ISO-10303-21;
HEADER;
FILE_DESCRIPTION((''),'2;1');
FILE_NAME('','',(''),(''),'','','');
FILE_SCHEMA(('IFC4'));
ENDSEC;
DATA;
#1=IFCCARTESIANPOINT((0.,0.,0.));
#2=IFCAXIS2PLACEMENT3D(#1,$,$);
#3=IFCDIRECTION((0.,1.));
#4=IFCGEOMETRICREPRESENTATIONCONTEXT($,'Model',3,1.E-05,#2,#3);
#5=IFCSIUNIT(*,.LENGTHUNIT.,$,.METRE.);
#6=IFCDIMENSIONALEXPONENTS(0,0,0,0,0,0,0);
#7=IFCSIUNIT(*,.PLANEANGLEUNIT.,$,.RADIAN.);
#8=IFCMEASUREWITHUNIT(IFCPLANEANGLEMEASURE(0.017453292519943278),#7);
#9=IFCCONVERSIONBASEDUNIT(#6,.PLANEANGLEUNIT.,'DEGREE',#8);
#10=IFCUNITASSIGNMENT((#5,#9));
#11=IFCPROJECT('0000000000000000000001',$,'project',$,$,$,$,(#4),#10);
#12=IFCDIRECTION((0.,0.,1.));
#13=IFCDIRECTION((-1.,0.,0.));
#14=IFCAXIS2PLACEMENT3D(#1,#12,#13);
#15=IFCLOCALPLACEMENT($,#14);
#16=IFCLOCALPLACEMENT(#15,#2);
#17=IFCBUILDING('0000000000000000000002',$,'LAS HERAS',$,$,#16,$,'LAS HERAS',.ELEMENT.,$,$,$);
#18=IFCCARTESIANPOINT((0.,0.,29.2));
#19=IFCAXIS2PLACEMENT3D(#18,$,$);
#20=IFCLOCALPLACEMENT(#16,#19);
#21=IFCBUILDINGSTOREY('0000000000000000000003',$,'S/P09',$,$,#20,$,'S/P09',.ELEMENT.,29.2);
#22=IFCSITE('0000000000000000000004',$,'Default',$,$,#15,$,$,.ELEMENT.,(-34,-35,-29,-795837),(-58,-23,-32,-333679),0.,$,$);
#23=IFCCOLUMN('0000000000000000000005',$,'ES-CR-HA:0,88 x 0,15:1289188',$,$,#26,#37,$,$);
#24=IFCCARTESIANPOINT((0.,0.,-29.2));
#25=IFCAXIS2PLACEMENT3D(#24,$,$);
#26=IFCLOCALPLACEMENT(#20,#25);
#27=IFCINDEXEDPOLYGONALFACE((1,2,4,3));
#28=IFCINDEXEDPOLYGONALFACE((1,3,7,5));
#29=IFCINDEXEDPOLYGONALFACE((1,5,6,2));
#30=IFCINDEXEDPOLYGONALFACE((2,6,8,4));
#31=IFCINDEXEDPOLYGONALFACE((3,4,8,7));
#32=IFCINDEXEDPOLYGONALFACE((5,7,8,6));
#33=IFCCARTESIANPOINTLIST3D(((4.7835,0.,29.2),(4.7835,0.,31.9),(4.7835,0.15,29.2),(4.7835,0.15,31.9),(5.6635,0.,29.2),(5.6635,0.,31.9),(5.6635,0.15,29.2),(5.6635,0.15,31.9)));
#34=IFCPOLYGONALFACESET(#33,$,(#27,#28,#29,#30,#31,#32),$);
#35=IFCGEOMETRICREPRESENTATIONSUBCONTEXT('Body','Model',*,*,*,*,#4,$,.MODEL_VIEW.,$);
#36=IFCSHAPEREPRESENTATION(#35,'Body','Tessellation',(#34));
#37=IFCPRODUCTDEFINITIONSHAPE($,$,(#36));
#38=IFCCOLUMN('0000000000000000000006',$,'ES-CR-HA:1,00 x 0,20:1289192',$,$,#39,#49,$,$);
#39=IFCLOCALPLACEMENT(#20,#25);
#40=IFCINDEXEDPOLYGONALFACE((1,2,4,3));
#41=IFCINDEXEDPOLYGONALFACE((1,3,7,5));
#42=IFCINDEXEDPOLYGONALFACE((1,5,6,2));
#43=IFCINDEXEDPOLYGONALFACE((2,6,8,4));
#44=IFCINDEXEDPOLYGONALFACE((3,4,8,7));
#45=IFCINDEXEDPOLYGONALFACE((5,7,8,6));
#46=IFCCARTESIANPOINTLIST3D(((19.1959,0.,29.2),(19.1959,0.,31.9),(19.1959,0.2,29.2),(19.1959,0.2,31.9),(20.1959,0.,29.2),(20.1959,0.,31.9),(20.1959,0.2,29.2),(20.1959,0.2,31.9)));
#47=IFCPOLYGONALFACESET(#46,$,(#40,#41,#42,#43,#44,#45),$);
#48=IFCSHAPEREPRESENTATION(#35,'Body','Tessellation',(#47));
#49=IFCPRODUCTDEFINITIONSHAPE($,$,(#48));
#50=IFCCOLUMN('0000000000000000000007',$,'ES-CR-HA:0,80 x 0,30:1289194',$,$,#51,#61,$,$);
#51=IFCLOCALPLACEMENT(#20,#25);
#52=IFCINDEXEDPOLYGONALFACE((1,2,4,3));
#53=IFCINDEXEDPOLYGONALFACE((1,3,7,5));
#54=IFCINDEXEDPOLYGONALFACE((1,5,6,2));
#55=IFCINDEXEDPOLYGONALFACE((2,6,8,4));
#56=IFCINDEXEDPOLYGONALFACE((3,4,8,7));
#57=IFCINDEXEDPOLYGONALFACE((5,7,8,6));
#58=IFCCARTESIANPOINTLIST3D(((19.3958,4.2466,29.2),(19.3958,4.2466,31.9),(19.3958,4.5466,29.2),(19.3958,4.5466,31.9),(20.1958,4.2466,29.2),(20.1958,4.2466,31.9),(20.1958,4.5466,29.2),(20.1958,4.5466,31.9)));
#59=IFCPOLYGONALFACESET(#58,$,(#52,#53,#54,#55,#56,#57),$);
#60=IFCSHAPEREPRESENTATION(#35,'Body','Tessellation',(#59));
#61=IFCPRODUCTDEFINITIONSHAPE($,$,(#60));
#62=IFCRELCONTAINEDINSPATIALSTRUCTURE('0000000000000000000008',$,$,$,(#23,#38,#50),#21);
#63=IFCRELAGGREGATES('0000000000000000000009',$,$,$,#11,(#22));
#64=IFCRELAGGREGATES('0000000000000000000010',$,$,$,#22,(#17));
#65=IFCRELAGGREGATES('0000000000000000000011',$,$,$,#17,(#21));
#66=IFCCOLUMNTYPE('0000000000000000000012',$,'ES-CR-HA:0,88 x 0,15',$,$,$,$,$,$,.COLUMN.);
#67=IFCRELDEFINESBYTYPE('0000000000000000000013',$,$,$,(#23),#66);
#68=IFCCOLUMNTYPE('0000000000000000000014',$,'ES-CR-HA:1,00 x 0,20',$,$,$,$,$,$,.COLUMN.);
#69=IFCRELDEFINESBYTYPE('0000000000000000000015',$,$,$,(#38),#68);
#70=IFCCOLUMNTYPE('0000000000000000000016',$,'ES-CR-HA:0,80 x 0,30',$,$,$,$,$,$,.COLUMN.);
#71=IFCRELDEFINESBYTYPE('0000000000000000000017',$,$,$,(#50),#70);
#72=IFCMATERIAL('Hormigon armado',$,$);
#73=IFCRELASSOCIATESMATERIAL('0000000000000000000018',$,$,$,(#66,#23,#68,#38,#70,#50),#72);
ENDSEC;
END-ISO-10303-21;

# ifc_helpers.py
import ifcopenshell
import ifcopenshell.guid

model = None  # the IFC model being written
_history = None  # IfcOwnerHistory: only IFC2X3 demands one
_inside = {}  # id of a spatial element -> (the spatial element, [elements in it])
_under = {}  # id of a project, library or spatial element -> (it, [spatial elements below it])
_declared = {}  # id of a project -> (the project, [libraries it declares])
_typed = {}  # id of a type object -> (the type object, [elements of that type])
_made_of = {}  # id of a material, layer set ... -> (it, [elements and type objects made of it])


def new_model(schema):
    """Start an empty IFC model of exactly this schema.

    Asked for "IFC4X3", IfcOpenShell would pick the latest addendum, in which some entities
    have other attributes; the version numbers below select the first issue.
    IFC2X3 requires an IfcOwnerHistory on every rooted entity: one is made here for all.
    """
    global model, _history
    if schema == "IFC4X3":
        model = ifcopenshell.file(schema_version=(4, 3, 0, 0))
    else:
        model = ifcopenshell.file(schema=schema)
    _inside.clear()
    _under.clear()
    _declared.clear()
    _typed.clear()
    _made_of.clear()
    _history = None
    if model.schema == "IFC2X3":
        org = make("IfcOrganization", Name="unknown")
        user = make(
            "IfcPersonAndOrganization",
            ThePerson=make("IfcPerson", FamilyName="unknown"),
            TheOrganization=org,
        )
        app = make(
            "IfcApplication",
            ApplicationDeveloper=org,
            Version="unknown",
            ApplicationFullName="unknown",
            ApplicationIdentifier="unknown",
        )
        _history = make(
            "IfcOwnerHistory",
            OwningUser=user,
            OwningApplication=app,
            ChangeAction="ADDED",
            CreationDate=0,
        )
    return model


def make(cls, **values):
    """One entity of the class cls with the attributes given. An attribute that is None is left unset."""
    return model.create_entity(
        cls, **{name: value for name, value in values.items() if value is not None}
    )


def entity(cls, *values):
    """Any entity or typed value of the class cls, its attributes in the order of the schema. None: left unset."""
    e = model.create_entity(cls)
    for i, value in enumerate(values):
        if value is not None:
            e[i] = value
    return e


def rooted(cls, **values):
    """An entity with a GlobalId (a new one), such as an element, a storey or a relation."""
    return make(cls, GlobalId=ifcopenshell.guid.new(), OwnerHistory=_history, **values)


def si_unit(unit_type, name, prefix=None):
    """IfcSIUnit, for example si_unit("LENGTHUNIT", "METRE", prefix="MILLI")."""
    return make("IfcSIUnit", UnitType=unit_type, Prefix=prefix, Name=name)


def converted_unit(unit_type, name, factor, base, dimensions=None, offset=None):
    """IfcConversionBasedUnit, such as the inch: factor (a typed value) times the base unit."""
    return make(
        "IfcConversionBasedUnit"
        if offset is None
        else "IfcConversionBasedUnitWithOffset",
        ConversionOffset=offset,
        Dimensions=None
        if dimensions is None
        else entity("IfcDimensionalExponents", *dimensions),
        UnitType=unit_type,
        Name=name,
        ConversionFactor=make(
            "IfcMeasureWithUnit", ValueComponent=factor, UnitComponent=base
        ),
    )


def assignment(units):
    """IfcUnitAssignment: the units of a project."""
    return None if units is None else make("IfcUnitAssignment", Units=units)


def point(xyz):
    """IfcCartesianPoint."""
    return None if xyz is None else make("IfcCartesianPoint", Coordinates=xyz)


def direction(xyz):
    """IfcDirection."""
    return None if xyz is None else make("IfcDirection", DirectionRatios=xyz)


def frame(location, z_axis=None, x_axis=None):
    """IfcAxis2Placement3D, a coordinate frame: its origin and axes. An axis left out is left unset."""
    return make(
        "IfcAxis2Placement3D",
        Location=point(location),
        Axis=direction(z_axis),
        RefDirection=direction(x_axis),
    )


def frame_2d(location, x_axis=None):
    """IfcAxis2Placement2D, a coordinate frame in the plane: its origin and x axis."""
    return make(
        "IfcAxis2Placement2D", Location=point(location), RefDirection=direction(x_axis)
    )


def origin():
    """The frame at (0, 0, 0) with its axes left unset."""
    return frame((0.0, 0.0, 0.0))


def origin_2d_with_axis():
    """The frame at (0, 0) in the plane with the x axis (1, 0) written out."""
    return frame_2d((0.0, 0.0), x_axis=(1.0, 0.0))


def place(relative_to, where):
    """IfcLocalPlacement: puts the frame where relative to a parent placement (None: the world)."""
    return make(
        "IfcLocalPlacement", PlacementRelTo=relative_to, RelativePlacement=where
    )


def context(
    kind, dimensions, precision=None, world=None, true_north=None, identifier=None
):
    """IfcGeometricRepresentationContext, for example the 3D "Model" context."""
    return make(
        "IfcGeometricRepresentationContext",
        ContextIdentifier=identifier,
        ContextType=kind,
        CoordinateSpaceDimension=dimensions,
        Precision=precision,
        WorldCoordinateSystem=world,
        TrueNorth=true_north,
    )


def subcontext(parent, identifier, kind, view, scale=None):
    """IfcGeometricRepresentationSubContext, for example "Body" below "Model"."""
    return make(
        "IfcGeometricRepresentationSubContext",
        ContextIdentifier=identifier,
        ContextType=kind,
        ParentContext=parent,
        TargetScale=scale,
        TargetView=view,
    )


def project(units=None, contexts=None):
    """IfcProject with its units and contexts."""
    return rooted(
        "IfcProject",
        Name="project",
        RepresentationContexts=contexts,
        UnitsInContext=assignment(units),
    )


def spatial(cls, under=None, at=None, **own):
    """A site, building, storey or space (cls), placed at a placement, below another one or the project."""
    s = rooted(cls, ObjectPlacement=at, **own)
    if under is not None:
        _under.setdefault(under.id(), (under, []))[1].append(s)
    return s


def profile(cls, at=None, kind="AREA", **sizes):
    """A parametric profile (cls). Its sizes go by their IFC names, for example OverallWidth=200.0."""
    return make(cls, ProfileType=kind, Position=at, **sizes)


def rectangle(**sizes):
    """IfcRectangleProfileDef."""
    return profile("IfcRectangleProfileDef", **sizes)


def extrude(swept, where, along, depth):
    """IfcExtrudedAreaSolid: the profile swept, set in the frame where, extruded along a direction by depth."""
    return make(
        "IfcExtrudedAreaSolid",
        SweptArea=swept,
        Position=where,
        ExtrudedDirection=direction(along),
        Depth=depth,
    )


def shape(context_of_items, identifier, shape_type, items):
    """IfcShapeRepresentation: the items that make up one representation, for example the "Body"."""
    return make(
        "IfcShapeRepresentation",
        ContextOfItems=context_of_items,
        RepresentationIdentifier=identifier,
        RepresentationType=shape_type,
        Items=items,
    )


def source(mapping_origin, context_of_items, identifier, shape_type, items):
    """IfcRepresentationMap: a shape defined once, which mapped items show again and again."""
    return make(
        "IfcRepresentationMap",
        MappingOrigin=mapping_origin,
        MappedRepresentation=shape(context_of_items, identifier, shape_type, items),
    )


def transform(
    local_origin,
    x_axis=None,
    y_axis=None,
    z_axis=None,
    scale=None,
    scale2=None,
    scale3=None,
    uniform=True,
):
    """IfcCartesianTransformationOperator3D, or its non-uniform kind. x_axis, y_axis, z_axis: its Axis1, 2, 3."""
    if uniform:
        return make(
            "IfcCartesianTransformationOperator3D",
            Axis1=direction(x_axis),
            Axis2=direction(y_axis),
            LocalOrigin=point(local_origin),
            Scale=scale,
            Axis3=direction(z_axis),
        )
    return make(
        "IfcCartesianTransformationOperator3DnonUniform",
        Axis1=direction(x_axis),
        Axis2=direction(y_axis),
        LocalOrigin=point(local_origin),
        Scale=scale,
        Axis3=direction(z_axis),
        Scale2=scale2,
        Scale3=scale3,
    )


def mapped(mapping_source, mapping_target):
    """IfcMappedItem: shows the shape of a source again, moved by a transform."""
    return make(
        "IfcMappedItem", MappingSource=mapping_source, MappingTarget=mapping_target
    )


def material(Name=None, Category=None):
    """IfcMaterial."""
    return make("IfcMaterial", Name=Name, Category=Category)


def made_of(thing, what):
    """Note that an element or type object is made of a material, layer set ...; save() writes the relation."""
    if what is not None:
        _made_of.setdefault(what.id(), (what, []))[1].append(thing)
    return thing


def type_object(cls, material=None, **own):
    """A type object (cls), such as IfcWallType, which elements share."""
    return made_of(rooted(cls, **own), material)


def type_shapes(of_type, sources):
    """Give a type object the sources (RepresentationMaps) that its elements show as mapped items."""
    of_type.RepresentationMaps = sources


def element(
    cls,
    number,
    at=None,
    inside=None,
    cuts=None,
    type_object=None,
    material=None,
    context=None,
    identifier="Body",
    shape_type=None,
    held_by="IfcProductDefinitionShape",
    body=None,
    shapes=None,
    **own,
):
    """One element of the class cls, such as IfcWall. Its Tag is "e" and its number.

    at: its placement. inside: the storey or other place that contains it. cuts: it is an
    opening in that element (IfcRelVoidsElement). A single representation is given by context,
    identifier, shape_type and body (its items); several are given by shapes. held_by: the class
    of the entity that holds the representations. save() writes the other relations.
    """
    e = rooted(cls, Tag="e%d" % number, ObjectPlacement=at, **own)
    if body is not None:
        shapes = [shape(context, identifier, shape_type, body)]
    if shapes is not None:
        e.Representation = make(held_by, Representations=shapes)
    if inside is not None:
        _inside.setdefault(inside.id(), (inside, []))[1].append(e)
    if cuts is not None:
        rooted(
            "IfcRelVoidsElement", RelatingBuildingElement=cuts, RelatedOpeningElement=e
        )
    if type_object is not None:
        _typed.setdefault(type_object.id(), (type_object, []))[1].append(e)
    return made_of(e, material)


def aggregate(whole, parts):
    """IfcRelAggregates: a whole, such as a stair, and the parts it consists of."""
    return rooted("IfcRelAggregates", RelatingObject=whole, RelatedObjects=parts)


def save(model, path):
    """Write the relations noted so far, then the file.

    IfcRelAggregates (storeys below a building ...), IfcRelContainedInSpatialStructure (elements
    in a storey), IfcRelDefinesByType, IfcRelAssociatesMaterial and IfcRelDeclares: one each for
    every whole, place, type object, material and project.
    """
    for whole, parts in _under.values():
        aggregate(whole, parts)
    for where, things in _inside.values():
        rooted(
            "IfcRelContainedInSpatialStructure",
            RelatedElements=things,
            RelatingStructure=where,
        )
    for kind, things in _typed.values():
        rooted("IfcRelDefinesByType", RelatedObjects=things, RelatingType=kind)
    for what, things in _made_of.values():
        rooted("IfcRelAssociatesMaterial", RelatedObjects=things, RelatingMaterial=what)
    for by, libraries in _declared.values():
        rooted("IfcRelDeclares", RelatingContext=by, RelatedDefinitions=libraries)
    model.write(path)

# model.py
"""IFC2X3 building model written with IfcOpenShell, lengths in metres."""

from ifc_helpers import new_model, entity, si_unit, converted_unit, direction, frame, frame_2d, origin, origin_2d_with_axis, place, context, subcontext, project, spatial, rectangle, extrude, source, transform, mapped, material, type_object, type_shapes, element, save


model = new_model("IFC2X3")

# Units and contexts
model_context = context("Model", 3, precision=1e-05, world=origin(), true_north=direction((0.0, 1.0)))
body_context = subcontext(model_context, "Body", "Model", "MODEL_VIEW")
ifc_project = project(units=[si_unit("LENGTHUNIT", "METRE"), converted_unit("PLANEANGLEUNIT", "DEGREE", entity("IfcPlaneAngleMeasure", 0.017453292519943278), si_unit("PLANEANGLEUNIT", "RADIAN"), dimensions=[0, 0, 0, 0, 0, 0, 0])], contexts=[model_context])

# Site, building, storey
site_placement = place(None, frame((0.0, 0.0, 0.0), z_axis=(0.0, 0.0, 1.0), x_axis=(-1.0, 0.0, 0.0)))
site = spatial("IfcSite", under=ifc_project, at=site_placement, Name="Default", CompositionType="ELEMENT", RefLatitude=(-34, -35, -29, -795837), RefLongitude=(-58, -23, -32, -333679), RefElevation=0.0)
building_placement = place(site_placement, origin())
building = spatial("IfcBuilding", under=site, at=building_placement, Name="LAS HERAS", LongName="LAS HERAS", CompositionType="ELEMENT")
storey_placement = place(building_placement, frame((0.0, 0.0, 29.2)))
storey = spatial("IfcBuildingStorey", under=building, at=storey_placement, Name="S/P09", LongName="S/P09", CompositionType="ELEMENT", Elevation=29.2)

# Columns
ifc_material = material(Name="Hormigon armado")
column_type_1 = type_object("IfcColumnType", Name="ES-CR-HA:0,88 x 0,15", PredefinedType="COLUMN", material=ifc_material)
shared_shape_1 = source(origin(), body_context, "Body", "SweptSolid", [
    extrude(rectangle(XDim=2.7, YDim=0.15, at=frame_2d((0.0, 0.0), x_axis=(1.0, 0.0))), frame((4.7835, 0.075, 30.55), z_axis=(1.0, 0.0, 0.0), x_axis=(0.0, 0.0, 1.0)), (0.0, 0.0, 1.0), 0.88),
])
type_shapes(column_type_1, [shared_shape_1])
column_1_placement = place(storey_placement, frame((0.0, 0.0, -29.2)))
element("IfcColumn", 1, at=column_1_placement, inside=storey, type_object=column_type_1, material=ifc_material, Name="ES-CR-HA:0,88 x 0,15:1289188", context=body_context, shape_type="MappedRepresentation", body=[
    mapped(shared_shape_1, transform((0.0, 0.0, 0.0), scale=1.0)),
])
column_type_2 = type_object("IfcColumnType", Name="ES-CR-HA:1,00 x 0,20", PredefinedType="COLUMN", material=ifc_material)
shared_shape_2 = source(origin(), body_context, "Body", "SweptSolid", [
    extrude(rectangle(XDim=2.7, YDim=0.2, at=frame_2d((0.0, 0.0), x_axis=(1.0, 0.0))), frame((19.1959, 0.1, 30.55), z_axis=(1.0, 0.0, 0.0), x_axis=(0.0, 0.0, 1.0)), (0.0, 0.0, 1.0), 1.0),
])
type_shapes(column_type_2, [shared_shape_2])
column_2_placement = place(storey_placement, frame((0.0, 0.0, -29.2)))
element("IfcColumn", 2, at=column_2_placement, inside=storey, type_object=column_type_2, material=ifc_material, Name="ES-CR-HA:1,00 x 0,20:1289192", context=body_context, shape_type="MappedRepresentation", body=[
    mapped(shared_shape_2, transform((0.0, 0.0, 0.0), scale=1.0)),
])
column_type_3 = type_object("IfcColumnType", Name="ES-CR-HA:0,80 x 0,30", PredefinedType="COLUMN", material=ifc_material)
shared_shape_3 = source(origin(), body_context, "Body", "SweptSolid", [
    extrude(rectangle(XDim=2.7, YDim=0.3, at=origin_2d_with_axis()), frame((19.3958, 4.3966, 30.55), z_axis=(1.0, 0.0, 0.0), x_axis=(0.0, 0.0, 1.0)), (0.0, 0.0, 1.0), 0.8),
])
type_shapes(column_type_3, [shared_shape_3])
column_3_placement = place(storey_placement, frame((0.0, 0.0, -29.2)))
element("IfcColumn", 3, at=column_3_placement, inside=storey, type_object=column_type_3, material=ifc_material, Name="ES-CR-HA:0,80 x 0,30:1289194", context=body_context, shape_type="MappedRepresentation", body=[
    mapped(shared_shape_3, transform((0.0, 0.0, 0.0), scale=1.0)),
])

save(model, "model.ifc")
